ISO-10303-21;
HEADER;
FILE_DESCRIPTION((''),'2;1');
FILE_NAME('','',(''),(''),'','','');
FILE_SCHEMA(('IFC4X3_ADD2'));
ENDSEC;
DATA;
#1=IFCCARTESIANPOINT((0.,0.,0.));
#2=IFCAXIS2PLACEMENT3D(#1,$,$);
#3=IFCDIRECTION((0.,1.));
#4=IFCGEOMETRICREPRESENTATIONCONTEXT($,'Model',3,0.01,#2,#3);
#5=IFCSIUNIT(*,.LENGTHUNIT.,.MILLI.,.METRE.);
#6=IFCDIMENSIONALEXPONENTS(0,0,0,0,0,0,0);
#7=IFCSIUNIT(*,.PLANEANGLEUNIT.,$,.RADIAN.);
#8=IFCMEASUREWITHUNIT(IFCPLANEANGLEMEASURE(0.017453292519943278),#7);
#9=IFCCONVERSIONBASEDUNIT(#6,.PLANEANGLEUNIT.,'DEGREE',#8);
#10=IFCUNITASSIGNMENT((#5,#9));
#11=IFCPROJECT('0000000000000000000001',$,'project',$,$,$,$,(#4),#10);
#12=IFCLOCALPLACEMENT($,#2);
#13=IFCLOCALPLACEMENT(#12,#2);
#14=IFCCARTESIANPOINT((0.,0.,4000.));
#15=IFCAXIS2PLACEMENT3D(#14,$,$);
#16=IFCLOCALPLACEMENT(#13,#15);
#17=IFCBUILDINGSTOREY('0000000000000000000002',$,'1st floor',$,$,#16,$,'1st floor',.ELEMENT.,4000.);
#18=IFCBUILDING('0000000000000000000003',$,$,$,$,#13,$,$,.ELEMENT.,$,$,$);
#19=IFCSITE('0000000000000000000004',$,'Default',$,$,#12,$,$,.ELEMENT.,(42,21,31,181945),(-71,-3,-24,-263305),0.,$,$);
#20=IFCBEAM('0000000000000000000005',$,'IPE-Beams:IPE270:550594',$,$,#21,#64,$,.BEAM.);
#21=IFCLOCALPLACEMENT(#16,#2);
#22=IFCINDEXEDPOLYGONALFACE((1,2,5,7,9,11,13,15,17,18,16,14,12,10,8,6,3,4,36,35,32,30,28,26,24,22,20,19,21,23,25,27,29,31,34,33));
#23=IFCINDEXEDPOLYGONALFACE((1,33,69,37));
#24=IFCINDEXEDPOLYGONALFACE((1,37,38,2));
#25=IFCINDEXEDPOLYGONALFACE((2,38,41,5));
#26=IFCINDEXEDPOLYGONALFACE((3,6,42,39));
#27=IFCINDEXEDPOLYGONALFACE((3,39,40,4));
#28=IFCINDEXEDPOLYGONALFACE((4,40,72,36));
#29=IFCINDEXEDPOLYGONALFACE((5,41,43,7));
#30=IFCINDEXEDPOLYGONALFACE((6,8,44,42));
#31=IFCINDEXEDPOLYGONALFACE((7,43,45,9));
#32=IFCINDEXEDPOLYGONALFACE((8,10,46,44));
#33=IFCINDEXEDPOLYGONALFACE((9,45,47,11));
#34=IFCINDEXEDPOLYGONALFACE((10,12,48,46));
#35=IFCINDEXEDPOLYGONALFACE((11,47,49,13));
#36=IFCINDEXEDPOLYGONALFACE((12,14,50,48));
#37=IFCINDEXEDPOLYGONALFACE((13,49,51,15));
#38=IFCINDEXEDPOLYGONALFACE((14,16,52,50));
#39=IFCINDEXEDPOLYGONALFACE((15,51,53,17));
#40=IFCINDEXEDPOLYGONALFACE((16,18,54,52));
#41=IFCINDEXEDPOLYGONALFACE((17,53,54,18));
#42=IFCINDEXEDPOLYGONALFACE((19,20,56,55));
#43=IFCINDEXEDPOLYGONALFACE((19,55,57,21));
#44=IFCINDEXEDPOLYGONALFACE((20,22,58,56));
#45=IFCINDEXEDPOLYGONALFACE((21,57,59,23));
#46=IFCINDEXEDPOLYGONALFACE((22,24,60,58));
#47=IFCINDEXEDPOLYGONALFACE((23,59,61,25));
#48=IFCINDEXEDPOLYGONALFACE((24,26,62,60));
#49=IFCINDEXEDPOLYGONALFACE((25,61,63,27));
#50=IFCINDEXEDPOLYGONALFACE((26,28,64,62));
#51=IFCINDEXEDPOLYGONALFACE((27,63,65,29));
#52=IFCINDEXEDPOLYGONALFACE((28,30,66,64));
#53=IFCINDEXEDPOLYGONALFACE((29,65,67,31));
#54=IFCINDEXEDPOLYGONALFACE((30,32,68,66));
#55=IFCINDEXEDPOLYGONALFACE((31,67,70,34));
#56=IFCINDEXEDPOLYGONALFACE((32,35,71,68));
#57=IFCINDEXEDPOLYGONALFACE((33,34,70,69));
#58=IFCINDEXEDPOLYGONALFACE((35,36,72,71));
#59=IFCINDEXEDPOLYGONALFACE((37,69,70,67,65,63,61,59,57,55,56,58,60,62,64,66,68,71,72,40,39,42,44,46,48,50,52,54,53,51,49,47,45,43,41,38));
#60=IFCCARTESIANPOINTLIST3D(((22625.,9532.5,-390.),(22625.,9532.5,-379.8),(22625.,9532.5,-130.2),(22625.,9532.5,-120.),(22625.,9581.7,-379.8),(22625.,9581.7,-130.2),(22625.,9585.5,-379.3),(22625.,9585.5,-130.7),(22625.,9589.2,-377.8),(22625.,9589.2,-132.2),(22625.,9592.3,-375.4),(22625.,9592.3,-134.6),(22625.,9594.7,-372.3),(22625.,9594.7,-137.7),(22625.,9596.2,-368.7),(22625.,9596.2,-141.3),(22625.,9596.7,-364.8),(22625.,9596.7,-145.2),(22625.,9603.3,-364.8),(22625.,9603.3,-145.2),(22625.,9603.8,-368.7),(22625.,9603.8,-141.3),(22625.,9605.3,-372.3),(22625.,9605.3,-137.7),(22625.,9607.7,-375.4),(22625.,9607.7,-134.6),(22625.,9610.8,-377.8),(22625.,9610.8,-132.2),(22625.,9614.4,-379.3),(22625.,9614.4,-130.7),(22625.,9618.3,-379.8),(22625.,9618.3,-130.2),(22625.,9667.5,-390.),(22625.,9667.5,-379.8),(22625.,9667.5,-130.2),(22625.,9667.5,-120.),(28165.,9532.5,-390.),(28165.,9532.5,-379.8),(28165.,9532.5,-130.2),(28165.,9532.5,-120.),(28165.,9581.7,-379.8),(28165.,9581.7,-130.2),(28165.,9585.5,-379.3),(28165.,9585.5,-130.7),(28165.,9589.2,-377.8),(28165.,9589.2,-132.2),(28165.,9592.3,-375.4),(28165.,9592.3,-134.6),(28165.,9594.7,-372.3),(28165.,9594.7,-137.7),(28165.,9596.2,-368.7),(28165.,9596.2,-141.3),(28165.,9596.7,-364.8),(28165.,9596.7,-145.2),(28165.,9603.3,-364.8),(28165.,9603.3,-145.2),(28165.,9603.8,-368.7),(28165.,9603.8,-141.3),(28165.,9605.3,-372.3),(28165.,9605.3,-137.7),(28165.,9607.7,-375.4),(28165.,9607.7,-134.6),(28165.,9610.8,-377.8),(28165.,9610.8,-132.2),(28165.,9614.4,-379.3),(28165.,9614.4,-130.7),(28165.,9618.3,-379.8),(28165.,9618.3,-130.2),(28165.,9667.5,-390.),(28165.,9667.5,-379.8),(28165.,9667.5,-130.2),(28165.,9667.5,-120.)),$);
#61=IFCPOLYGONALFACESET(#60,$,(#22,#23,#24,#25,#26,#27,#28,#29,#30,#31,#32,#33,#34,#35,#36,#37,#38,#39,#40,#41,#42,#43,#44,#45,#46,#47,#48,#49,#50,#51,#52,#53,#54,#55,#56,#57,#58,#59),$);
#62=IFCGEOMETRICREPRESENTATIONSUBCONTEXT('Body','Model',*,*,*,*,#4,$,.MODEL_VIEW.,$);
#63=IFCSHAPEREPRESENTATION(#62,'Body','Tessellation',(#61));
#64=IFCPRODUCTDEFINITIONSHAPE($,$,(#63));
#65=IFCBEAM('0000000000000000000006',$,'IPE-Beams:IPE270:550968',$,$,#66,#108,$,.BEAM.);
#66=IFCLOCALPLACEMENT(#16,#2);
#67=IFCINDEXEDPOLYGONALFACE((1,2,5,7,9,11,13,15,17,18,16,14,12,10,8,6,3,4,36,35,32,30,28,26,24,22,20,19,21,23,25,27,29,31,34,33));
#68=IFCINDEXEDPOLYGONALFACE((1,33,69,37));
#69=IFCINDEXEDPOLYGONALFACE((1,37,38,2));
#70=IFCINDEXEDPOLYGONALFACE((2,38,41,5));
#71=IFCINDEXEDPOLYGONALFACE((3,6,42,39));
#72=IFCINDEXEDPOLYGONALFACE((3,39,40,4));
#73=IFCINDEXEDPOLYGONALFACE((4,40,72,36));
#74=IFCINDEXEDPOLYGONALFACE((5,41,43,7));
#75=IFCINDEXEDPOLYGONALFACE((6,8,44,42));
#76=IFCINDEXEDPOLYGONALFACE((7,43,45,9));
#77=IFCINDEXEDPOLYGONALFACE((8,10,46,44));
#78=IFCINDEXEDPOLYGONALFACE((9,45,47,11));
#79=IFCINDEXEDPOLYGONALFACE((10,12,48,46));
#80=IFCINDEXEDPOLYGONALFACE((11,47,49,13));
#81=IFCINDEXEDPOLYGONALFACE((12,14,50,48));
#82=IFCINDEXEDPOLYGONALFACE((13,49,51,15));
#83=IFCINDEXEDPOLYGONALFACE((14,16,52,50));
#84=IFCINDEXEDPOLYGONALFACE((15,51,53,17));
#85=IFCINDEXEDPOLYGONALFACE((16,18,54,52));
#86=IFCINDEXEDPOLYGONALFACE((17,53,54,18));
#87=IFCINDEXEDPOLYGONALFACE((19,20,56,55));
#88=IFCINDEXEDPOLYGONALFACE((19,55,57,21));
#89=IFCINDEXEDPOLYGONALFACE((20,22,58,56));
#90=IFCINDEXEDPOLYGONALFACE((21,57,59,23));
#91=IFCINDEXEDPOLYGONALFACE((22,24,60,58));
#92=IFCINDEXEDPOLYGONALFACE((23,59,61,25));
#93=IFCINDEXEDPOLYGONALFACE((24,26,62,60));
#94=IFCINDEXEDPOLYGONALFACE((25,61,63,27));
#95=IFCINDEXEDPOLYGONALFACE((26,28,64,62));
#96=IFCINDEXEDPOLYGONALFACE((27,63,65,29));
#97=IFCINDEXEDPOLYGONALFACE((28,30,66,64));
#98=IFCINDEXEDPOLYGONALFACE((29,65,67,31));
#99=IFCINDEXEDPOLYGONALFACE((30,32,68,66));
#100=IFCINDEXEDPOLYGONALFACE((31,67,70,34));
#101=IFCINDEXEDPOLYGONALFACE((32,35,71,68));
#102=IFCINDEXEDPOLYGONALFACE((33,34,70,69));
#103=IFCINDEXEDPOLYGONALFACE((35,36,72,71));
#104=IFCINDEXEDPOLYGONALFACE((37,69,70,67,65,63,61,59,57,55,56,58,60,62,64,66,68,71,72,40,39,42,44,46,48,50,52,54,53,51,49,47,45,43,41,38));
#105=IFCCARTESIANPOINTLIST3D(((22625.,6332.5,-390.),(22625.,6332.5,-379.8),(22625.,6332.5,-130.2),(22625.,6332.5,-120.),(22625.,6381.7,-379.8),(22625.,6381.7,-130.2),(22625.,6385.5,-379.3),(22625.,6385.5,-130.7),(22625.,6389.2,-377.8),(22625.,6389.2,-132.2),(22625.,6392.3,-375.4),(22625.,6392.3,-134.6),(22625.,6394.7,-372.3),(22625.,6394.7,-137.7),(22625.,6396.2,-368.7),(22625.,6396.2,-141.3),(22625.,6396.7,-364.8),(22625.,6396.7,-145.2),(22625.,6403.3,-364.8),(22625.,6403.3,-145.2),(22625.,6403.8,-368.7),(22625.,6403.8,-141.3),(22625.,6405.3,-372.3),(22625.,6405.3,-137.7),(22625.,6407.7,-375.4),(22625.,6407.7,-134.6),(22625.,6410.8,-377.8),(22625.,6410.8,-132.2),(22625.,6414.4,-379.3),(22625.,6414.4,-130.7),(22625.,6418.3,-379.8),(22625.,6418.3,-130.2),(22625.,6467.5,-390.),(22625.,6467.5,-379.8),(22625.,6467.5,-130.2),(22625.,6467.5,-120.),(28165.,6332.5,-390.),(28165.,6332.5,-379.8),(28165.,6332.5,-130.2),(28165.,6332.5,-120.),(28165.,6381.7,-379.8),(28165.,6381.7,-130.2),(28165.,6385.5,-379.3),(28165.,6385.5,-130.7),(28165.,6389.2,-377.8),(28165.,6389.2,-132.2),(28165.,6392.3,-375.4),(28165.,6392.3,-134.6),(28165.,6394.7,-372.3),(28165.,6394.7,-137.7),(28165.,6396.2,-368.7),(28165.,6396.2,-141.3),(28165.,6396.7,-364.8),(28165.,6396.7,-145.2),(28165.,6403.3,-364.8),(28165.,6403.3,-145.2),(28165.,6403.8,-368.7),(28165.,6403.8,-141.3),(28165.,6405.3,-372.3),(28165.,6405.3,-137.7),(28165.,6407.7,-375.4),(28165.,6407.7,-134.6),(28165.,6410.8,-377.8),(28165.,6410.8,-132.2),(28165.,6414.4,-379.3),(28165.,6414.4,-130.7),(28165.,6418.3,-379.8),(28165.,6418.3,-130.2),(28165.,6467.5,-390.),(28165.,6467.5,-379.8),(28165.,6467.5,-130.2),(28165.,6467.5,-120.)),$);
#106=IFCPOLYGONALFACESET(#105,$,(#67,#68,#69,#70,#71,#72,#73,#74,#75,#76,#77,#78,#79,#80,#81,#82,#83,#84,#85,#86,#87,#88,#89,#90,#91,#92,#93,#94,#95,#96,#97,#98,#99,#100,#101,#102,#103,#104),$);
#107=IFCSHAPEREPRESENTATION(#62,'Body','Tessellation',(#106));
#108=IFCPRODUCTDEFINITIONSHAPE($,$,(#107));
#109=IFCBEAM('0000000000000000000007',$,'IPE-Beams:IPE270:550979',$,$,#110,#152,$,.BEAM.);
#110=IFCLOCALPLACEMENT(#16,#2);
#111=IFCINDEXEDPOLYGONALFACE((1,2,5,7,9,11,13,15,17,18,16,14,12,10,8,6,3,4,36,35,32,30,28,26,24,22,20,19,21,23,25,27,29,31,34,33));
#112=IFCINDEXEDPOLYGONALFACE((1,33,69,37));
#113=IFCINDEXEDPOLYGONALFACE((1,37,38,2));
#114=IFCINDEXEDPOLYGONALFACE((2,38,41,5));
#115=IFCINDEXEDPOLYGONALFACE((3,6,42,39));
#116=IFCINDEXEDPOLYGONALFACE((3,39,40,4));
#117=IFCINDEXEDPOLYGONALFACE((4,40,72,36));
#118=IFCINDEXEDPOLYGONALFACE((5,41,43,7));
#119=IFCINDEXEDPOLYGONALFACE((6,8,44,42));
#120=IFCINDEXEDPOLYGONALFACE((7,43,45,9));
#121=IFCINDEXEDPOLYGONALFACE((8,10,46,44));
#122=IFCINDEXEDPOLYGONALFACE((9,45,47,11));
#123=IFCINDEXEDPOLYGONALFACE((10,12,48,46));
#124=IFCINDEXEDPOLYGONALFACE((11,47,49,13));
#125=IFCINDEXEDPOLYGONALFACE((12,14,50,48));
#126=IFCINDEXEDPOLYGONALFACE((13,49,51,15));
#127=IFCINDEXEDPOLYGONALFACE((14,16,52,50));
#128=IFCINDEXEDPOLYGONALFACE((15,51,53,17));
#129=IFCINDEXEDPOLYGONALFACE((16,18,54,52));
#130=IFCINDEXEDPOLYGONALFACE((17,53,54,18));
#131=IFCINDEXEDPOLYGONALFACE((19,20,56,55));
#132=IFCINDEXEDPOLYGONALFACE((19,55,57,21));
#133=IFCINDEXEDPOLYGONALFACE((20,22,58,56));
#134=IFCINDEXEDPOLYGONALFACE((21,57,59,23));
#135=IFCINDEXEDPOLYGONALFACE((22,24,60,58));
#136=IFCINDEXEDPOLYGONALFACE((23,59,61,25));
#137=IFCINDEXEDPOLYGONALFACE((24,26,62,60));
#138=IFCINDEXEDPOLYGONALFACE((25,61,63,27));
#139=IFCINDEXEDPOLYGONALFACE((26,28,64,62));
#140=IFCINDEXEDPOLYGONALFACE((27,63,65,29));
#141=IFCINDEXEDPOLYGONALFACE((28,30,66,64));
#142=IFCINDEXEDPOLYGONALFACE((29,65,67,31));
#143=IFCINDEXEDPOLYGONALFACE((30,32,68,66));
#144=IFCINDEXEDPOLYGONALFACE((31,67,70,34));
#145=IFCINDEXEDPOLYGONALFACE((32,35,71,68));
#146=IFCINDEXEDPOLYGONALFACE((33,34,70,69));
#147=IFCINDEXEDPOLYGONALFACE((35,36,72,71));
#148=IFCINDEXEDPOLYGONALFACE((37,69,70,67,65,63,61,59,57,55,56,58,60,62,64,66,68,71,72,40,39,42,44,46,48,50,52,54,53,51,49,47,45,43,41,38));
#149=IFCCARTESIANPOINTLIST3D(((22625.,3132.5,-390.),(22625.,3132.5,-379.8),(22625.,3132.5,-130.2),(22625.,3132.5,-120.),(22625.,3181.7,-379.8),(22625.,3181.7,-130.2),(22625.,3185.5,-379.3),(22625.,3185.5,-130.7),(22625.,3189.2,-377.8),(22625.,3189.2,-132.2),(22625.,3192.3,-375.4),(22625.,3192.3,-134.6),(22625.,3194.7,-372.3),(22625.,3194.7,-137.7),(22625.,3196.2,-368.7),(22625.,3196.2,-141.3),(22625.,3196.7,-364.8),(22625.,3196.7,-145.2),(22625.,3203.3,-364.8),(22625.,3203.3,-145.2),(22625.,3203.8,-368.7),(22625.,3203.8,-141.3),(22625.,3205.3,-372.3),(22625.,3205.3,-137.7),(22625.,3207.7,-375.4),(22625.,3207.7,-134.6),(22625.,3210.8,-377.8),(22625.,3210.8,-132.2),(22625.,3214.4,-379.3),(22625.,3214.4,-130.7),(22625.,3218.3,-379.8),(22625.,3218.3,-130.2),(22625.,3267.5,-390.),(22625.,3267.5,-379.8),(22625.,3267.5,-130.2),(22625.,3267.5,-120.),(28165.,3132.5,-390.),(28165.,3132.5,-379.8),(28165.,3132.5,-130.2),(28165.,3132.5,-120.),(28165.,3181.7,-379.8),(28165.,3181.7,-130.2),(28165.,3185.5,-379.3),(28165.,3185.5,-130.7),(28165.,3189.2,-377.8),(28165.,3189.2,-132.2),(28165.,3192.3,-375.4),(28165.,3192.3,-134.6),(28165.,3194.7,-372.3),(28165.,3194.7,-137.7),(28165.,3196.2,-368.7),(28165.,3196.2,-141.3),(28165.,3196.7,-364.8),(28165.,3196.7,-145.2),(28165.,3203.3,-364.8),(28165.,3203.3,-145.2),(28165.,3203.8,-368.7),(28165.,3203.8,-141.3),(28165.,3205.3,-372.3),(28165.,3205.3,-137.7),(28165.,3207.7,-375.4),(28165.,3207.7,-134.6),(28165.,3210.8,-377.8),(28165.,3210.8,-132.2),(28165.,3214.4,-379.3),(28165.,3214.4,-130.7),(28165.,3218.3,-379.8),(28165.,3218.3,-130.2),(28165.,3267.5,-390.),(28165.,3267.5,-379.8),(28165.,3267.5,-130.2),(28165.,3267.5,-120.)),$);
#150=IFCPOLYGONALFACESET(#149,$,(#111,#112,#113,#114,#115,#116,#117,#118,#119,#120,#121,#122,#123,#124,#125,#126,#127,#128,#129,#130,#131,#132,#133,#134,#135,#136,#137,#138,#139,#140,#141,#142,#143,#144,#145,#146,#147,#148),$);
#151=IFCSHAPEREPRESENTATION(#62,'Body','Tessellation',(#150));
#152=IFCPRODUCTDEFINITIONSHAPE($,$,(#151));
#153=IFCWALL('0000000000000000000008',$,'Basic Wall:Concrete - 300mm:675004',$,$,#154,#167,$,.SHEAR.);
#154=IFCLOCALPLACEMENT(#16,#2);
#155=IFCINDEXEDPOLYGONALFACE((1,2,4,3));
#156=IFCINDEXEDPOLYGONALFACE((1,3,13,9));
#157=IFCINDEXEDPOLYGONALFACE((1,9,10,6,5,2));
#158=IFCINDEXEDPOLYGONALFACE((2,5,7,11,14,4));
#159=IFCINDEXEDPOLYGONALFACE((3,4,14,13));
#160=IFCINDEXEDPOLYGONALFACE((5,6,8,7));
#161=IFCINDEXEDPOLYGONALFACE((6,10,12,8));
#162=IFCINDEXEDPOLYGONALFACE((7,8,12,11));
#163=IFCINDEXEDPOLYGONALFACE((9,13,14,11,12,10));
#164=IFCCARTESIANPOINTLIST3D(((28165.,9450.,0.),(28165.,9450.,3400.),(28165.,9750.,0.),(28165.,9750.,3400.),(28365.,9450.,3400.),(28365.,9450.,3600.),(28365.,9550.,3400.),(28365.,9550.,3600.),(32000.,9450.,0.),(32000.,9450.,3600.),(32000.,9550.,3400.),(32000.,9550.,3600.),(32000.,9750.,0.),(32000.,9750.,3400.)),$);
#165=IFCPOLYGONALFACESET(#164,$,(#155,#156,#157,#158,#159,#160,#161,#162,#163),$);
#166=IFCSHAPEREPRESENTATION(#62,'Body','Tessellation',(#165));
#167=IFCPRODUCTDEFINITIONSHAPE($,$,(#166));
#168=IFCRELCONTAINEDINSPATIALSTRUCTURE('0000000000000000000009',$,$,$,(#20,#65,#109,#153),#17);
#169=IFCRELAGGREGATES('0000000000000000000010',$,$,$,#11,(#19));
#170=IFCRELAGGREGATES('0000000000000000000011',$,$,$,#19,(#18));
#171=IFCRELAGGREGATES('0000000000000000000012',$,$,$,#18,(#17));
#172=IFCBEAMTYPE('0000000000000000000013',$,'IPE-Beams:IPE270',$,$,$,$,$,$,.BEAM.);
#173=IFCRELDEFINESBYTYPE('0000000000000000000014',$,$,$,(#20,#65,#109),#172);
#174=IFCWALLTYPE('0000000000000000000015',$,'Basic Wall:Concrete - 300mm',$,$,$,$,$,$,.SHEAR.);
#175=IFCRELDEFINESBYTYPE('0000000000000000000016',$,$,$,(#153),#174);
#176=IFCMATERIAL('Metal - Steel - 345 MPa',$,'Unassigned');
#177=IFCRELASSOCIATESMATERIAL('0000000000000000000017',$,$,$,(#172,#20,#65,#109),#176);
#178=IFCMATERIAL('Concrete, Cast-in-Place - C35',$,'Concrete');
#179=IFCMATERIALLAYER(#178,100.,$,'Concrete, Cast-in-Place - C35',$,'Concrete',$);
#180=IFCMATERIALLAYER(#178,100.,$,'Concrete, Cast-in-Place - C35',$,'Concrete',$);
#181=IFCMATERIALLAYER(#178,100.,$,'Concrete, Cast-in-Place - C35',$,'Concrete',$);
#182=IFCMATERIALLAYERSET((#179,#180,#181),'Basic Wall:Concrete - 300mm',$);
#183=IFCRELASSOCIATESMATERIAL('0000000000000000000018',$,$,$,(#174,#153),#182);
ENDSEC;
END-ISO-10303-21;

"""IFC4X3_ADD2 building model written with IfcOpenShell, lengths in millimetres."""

from ifc_helpers import new_model, entity, si_unit, converted_unit, direction, frame, frame_2d, origin, place, context, subcontext, project, spatial, polyline, circle_curve, parameter, trimmed, segment, composite_curve, rectangle, outline, extrude, clip, bounded_halfspace, source, transform, mapped, material, layer, layer_set, material_profile, profile_set, profile_usage, type_object, type_shapes, element, save


model = new_model("IFC4X3_ADD2")

# Units and contexts
model_context = context("Model", 3, precision=0.01, world=origin(), true_north=direction((0.0, 1.0)))
body_context = subcontext(model_context, "Body", "Model", "MODEL_VIEW")
ifc_project = project(units=[si_unit("LENGTHUNIT", "METRE", prefix="MILLI"), converted_unit("PLANEANGLEUNIT", "DEGREE", entity("IfcPlaneAngleMeasure", 0.017453292519943278), si_unit("PLANEANGLEUNIT", "RADIAN"), dimensions=[0, 0, 0, 0, 0, 0, 0])], contexts=[model_context])

# Site, building, storey
site_placement = place(None, origin())
site = spatial("IfcSite", under=ifc_project, at=site_placement, Name="Default", CompositionType="ELEMENT", RefLatitude=(42, 21, 31, 181945), RefLongitude=(-71, -3, -24, -263305), RefElevation=0.0)
building_placement = place(site_placement, origin())
building = spatial("IfcBuilding", under=site, at=building_placement, CompositionType="ELEMENT")
storey_placement = place(building_placement, frame((0.0, 0.0, 4000.0)))
storey = spatial("IfcBuildingStorey", under=building, at=storey_placement, Name="1st floor", LongName="1st floor", CompositionType="ELEMENT", Elevation=4000.0)

# Shared definitions
ifc_material_1 = material(Name="Concrete, Cast-in-Place - C35", Category="Concrete")

# Beams
ifc_material_2 = material(Name="Metal - Steel - 345 MPa", Category="Unassigned")
ifc_material_profile_1 = material_profile(ifc_material_2, outline(composite_curve([segment(polyline([(-67.5, -124.8), (-67.5, -135.0)]), True, "CONTINUOUS"), segment(polyline([(-67.5, -135.0), (67.5, -135.0)]), True, "CONTINUOUS"), segment(polyline([(67.5, -135.0), (67.5, -124.8)]), True, "CONTINUOUS"), segment(polyline([(67.5, -124.8), (18.3, -124.8)]), True, "CONTINUOUS"), segment(trimmed(circle_curve(frame_2d((18.3, -109.8), x_axis=(1.0, 0.0)), 15.0), [parameter(180.0)], [parameter(270.0)], True, "PARAMETER"), False, "CONTINUOUS"), segment(polyline([(3.3, -109.8), (3.3, 109.8)]), True, "CONTINUOUS"), segment(trimmed(circle_curve(frame_2d((18.3, 109.8), x_axis=(1.0, 0.0)), 15.0), [parameter(90.0)], [parameter(180.0)], True, "PARAMETER"), False, "CONTINUOUS"), segment(polyline([(18.3, 124.8), (67.5, 124.8)]), True, "CONTINUOUS"), segment(polyline([(67.5, 124.8), (67.5, 135.0)]), True, "CONTINUOUS"), segment(polyline([(67.5, 135.0), (-67.5, 135.0)]), True, "CONTINUOUS"), segment(polyline([(-67.5, 135.0), (-67.5, 124.8)]), True, "CONTINUOUS"), segment(polyline([(-67.5, 124.8), (-18.3, 124.8)]), True, "CONTINUOUS"), segment(trimmed(circle_curve(frame_2d((-18.3, 109.8), x_axis=(1.0, 0.0)), 15.0), [parameter(360.0)], [parameter(90.0)], True, "PARAMETER"), False, "CONTINUOUS"), segment(polyline([(-3.3, 109.8), (-3.3, -109.8)]), True, "CONTINUOUS"), segment(trimmed(circle_curve(frame_2d((-18.3, -109.8), x_axis=(1.0, 0.0)), 15.0), [parameter(270.0)], [parameter(0.0)], True, "PARAMETER"), False, "CONTINUOUS"), segment(polyline([(-18.3, -124.8), (-67.5, -124.8)]), True, "CONTINUOUS")], self_intersect=False)), Name="IPE270")
ifc_profile_set_1 = profile_set([ifc_material_profile_1], Name="IPE270")
ifc_profile_usage_1 = profile_usage(ifc_profile_set_1, cardinal=8)
beam_type_1 = type_object("IfcBeamType", Name="IPE-Beams:IPE270", PredefinedType="BEAM", material=ifc_profile_set_1)
shared_shape_1 = source(origin(), body_context, "Body", "SweptSolid", [
    extrude(outline(composite_curve([segment(polyline([(-67.5, -124.8), (-67.5, -135.0)]), True, "CONTINUOUS"), segment(polyline([(-67.5, -135.0), (67.5, -135.0)]), True, "CONTINUOUS"), segment(polyline([(67.5, -135.0), (67.5, -124.8)]), True, "CONTINUOUS"), segment(polyline([(67.5, -124.8), (18.3, -124.8)]), True, "CONTINUOUS"), segment(trimmed(circle_curve(frame_2d((18.3, -109.8), x_axis=(1.0, 0.0)), 15.0), [parameter(180.0)], [parameter(270.0)], True, "PARAMETER"), False, "CONTINUOUS"), segment(polyline([(3.3, -109.8), (3.3, 109.8)]), True, "CONTINUOUS"), segment(trimmed(circle_curve(frame_2d((18.3, 109.8), x_axis=(1.0, 0.0)), 15.0), [parameter(90.0)], [parameter(180.0)], True, "PARAMETER"), False, "CONTINUOUS"), segment(polyline([(18.3, 124.8), (67.5, 124.8)]), True, "CONTINUOUS"), segment(polyline([(67.5, 124.8), (67.5, 135.0)]), True, "CONTINUOUS"), segment(polyline([(67.5, 135.0), (-67.5, 135.0)]), True, "CONTINUOUS"), segment(polyline([(-67.5, 135.0), (-67.5, 124.8)]), True, "CONTINUOUS"), segment(polyline([(-67.5, 124.8), (-18.3, 124.8)]), True, "CONTINUOUS"), segment(trimmed(circle_curve(frame_2d((-18.3, 109.8), x_axis=(1.0, 0.0)), 15.0), [parameter(360.0)], [parameter(90.0)], True, "PARAMETER"), False, "CONTINUOUS"), segment(polyline([(-3.3, 109.8), (-3.3, -109.8)]), True, "CONTINUOUS"), segment(trimmed(circle_curve(frame_2d((-18.3, -109.8), x_axis=(1.0, 0.0)), 15.0), [parameter(270.0)], [parameter(0.0)], True, "PARAMETER"), False, "CONTINUOUS"), segment(polyline([(-18.3, -124.8), (-67.5, -124.8)]), True, "CONTINUOUS")], self_intersect=False)), frame((-2945.0, 0.0, 0.0), z_axis=(-1.0, 0.0, 0.0), x_axis=(0.0, -1.0, 0.0)), (0.0, 0.0, -1.0), 5540.0),
])
type_shapes(beam_type_1, [shared_shape_1])
for number, where, name in (
    (1, (25570.0, 9600.0, -255.0), "IPE-Beams:IPE270:550594"),
    (2, (25570.0, 6400.0, -255.0), "IPE-Beams:IPE270:550968"),
    (3, (25570.0, 3200.0, -255.0), "IPE-Beams:IPE270:550979"),
):
    element("IfcBeam", number, at=place(storey_placement, frame(where)), inside=storey, type_object=beam_type_1, material=ifc_profile_usage_1, Name=name, PredefinedType="BEAM", context=body_context, shape_type="MappedRepresentation", body=[
        mapped(shared_shape_1, transform((0.0, 0.0, 0.0), scale=1.0)),
    ])

# Wall
ifc_layer_1 = layer(ifc_material_1, 100.0, Name="Concrete, Cast-in-Place - C35", Category="Concrete")
ifc_layer_2 = layer(ifc_material_1, 100.0, Name="Concrete, Cast-in-Place - C35", Category="Concrete")
ifc_layer_3 = layer(ifc_material_1, 100.0, Name="Concrete, Cast-in-Place - C35", Category="Concrete")
ifc_layer_set = layer_set([ifc_layer_1, ifc_layer_2, ifc_layer_3], Name="Basic Wall:Concrete - 300mm")
wall_type = type_object("IfcWallType", Name="Basic Wall:Concrete - 300mm", PredefinedType="SHEAR", material=ifc_layer_set)
wall_1_placement = place(storey_placement, frame((28165.0, 9600.0, 0.0)))
element("IfcWall", 4, at=wall_1_placement, inside=storey, type_object=wall_type, material=ifc_layer_set, Name="Basic Wall:Concrete - 300mm:675004", PredefinedType="SHEAR", context=body_context, shape_type="Clipping", body=[
    clip(extrude(rectangle(XDim=3835.0, YDim=300.0, at=frame_2d((1917.5, 0.0), x_axis=(-1.0, 0.0))), origin(), (0.0, 0.0, 1.0), 3600.0), bounded_halfspace(frame((3835.0, -50.0, 3400.0)), False, frame((3835.0, -50.0, 3400.0)), polyline([(0.0, 0.0), (0.0, 200.0), (-3835.0, 200.0), (-3835.0, -100.0), (-3635.0, -100.0), (-3635.0, 0.0), (0.0, 0.0)]))),
])

save(model, "model.ifc")
